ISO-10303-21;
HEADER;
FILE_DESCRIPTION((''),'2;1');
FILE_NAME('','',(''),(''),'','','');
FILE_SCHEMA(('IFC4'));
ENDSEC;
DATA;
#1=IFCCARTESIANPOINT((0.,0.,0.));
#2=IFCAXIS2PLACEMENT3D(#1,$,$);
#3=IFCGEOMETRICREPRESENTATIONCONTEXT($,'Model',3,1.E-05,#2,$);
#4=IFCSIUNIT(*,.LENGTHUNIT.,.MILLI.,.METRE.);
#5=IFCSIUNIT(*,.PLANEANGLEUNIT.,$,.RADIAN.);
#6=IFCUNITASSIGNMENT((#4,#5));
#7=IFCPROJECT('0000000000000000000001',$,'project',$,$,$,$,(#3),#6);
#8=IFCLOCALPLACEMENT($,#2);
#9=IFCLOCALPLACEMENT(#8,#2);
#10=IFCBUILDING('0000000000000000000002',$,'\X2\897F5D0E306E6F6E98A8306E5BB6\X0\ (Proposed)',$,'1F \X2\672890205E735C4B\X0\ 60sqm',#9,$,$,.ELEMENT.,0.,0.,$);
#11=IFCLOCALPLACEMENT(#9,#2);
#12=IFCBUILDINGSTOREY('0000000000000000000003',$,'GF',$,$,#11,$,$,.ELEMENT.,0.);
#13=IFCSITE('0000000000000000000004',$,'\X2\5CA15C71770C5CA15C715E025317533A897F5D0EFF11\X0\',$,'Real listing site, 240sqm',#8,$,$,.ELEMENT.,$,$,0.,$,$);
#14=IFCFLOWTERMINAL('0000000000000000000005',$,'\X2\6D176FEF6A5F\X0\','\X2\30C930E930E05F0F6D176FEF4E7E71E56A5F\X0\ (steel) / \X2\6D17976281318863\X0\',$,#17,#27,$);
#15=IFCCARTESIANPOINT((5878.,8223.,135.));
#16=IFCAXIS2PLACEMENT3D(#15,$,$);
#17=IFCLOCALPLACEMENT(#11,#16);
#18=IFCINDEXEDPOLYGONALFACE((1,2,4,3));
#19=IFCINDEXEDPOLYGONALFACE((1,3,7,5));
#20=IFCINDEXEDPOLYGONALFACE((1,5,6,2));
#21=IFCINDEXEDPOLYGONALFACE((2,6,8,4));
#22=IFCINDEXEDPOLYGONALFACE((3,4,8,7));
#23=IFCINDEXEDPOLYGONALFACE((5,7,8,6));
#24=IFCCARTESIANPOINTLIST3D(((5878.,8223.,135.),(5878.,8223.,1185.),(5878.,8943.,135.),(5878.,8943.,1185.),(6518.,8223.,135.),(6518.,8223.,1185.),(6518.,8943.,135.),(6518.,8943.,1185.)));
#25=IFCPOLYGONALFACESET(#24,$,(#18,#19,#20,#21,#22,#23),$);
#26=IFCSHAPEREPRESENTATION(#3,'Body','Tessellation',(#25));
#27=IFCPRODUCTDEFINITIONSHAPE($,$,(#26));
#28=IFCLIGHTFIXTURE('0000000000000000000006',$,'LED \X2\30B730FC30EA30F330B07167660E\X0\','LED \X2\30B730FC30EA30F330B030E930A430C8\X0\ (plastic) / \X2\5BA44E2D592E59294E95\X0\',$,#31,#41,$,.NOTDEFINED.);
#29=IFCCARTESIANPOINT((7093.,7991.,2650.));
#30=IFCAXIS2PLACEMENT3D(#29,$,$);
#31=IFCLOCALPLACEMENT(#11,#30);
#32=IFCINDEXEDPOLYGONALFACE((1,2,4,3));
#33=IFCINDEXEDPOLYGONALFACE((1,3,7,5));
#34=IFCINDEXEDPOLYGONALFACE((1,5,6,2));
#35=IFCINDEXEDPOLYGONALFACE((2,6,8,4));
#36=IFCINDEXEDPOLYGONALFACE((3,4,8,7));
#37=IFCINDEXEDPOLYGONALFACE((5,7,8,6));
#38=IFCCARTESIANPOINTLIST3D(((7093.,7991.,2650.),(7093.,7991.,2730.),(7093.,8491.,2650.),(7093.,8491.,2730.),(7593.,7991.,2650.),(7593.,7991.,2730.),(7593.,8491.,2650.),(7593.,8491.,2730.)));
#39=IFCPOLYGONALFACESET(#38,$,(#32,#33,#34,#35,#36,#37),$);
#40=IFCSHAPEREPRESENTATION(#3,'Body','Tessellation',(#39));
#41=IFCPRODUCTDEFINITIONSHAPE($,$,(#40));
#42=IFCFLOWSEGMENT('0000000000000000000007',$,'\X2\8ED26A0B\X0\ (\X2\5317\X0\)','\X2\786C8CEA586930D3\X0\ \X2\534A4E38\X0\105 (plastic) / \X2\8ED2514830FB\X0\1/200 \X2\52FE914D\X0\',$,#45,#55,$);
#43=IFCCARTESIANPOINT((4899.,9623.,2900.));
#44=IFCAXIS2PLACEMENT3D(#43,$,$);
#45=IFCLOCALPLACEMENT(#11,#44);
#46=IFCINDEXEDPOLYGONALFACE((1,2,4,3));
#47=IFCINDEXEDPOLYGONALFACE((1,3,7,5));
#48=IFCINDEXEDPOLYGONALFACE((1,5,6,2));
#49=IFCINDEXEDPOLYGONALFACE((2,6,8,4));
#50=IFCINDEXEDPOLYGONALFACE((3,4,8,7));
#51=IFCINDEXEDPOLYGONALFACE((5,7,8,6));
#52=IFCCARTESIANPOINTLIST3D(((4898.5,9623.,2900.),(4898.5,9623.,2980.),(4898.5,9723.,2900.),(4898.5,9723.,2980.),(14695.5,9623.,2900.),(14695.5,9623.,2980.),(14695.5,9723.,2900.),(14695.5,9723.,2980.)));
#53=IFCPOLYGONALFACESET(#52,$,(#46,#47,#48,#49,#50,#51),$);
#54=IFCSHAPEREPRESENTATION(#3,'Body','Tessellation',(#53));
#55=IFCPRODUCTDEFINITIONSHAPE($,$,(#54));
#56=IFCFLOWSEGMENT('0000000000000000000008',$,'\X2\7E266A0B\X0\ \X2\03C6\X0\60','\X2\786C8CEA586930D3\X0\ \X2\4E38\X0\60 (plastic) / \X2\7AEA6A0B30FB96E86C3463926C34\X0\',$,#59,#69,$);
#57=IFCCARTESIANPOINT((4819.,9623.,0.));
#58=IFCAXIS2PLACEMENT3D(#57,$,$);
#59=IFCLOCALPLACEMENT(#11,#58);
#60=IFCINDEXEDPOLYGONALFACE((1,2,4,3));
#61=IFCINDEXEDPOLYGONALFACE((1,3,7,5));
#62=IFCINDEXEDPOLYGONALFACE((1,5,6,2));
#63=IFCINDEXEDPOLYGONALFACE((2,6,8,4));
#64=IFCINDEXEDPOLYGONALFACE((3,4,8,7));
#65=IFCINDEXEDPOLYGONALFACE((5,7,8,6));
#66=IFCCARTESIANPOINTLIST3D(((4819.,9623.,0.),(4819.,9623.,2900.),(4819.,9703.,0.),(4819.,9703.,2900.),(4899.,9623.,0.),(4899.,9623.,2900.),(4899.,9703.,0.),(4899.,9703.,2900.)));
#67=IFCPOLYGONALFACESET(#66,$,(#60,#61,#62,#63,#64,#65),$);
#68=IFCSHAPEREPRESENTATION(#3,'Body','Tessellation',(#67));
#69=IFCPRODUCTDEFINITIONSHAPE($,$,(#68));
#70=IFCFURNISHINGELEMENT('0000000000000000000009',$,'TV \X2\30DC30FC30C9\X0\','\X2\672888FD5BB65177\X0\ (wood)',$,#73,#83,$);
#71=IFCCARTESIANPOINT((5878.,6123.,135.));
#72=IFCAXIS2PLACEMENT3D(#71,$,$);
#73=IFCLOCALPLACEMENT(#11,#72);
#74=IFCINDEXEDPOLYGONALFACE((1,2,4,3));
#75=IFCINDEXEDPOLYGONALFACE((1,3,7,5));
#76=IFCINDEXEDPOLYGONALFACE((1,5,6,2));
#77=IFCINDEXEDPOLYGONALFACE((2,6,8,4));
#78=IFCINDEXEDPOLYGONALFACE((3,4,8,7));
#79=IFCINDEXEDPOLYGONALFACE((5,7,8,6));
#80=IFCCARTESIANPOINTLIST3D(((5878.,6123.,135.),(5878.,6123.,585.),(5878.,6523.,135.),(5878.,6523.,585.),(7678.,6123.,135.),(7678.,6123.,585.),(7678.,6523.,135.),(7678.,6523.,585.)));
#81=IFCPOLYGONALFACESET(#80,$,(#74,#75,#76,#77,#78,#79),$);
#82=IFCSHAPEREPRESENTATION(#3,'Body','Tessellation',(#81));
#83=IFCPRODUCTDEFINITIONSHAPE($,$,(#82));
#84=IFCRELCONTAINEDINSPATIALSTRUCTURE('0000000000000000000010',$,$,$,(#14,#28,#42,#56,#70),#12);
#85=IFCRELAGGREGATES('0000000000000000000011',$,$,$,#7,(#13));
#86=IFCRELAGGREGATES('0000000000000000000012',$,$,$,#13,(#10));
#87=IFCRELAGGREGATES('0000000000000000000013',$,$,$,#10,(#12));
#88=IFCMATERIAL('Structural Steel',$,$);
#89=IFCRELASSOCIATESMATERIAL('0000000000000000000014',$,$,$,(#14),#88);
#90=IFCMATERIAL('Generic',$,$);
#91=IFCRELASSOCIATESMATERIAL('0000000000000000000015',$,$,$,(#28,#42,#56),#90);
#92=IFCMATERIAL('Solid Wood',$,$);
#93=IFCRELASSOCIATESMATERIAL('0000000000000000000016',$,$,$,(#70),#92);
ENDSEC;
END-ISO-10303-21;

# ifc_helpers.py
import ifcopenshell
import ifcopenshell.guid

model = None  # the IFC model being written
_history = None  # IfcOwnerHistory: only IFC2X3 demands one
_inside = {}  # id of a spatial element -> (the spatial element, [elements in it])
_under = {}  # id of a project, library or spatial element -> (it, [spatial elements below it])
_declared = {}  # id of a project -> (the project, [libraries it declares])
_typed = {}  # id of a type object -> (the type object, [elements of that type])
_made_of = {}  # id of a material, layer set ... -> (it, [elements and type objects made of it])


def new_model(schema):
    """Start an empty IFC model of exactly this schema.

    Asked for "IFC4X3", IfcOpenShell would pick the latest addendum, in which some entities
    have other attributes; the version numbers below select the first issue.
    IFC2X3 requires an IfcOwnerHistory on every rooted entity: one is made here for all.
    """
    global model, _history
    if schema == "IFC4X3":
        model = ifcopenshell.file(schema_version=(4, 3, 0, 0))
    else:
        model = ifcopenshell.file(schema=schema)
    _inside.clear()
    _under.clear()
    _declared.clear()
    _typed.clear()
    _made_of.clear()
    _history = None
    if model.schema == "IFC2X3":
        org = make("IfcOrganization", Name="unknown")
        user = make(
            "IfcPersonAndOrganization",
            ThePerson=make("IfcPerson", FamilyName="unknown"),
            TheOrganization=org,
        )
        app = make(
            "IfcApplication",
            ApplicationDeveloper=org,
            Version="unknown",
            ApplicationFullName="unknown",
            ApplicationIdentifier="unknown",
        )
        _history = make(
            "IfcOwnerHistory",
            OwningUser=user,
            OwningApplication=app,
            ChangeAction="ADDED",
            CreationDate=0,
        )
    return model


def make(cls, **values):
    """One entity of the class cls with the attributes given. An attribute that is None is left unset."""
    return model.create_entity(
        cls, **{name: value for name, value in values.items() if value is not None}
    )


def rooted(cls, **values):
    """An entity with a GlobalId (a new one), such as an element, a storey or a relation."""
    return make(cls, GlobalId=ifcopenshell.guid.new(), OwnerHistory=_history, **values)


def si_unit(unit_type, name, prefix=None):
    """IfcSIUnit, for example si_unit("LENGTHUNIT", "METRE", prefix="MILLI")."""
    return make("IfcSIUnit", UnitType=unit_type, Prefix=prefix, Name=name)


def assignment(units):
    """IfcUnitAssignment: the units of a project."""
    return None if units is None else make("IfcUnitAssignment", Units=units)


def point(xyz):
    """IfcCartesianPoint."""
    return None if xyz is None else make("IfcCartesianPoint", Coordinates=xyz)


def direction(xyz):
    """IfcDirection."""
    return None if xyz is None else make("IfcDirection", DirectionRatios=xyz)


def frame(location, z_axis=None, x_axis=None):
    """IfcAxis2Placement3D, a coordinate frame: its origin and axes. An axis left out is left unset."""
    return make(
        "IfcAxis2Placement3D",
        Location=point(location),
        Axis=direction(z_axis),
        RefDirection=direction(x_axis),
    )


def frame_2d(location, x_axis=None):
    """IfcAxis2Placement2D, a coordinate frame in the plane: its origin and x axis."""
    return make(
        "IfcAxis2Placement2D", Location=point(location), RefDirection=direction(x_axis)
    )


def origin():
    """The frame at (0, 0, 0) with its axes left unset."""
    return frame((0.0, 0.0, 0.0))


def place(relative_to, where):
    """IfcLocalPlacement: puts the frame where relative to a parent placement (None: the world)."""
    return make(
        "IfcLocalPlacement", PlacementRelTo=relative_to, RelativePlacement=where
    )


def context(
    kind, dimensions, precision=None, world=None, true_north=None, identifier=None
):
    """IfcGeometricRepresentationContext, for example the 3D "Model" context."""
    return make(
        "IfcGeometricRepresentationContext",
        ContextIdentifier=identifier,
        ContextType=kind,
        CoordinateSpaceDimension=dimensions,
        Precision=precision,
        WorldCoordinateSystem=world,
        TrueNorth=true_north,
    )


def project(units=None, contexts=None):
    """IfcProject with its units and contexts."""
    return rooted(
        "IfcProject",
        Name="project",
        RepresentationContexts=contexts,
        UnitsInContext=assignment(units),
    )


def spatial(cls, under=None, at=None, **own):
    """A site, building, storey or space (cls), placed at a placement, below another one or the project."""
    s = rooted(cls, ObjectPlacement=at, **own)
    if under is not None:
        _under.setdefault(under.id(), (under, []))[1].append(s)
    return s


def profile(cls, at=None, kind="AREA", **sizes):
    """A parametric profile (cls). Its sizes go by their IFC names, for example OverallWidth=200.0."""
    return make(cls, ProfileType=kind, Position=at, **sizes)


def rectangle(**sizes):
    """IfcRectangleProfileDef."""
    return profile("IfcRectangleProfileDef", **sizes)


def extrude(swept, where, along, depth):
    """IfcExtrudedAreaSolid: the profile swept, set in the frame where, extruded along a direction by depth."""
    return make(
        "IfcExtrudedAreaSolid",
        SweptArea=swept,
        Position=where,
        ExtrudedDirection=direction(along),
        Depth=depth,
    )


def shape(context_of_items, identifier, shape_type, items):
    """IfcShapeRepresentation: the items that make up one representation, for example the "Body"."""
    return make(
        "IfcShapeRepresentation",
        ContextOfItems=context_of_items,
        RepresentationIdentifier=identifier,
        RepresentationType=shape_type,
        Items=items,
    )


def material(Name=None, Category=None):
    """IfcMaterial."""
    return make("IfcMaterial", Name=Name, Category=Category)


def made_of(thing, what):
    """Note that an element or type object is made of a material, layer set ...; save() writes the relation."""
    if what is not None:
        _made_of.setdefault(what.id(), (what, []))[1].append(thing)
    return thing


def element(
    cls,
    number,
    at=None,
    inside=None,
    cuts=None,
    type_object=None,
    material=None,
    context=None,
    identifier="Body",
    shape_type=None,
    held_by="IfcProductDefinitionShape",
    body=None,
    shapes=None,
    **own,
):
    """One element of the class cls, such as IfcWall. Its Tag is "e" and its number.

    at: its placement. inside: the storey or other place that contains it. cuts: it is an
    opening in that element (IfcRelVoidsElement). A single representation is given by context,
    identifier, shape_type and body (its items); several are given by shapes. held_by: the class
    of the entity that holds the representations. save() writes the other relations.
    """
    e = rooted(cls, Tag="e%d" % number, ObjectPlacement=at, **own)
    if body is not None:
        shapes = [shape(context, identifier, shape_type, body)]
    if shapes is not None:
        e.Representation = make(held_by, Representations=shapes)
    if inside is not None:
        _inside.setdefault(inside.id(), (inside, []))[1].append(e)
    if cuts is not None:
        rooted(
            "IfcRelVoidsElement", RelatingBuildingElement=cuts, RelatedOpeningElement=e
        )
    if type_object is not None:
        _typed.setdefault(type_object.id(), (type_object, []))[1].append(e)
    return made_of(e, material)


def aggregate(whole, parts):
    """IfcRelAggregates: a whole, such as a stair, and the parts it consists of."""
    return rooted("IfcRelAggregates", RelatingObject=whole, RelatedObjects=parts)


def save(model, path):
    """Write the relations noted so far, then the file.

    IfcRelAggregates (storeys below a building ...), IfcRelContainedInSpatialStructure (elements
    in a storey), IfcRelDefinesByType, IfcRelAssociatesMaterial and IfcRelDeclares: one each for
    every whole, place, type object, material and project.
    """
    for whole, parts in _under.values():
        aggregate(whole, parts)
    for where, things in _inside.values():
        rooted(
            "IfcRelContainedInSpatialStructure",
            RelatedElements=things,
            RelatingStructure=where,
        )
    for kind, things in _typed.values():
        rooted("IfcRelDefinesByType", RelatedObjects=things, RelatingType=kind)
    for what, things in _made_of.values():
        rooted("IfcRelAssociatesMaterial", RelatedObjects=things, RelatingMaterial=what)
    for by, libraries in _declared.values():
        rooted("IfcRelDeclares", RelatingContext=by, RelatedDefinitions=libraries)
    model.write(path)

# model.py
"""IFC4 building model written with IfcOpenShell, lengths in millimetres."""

from ifc_helpers import new_model, si_unit, frame, frame_2d, origin, place, context, project, spatial, rectangle, extrude, material, element, save


model = new_model("IFC4")

# Units and contexts
model_context = context("Model", 3, precision=1e-05, world=origin())
ifc_project = project(units=[si_unit("LENGTHUNIT", "METRE", prefix="MILLI"), si_unit("PLANEANGLEUNIT", "RADIAN")], contexts=[model_context])

# Site, building, storey
site_placement = place(None, origin())
site = spatial("IfcSite", under=ifc_project, at=site_placement, Name="岡山県岡山市北区西崎１", ObjectType="Real listing site, 240sqm", CompositionType="ELEMENT", RefElevation=0.0)
building_placement = place(site_placement, origin())
building = spatial("IfcBuilding", under=site, at=building_placement, Name="西崎の潮風の家 (Proposed)", ObjectType="1F 木造平屋 60sqm", CompositionType="ELEMENT", ElevationOfRefHeight=0.0, ElevationOfTerrain=0.0)
storey_placement = place(building_placement, origin())
storey = spatial("IfcBuildingStorey", under=building, at=storey_placement, Name="GF", CompositionType="ELEMENT", Elevation=0.0)

# Shared definitions
ifc_material_1 = material(Name="Solid Wood")

# Shared definitions
ifc_material_2 = material(Name="Structural Steel")

# Shared definitions
ifc_material_3 = material(Name="Generic")

# Flow terminal
flow_terminal_placement = place(storey_placement, frame((5878.0, 8223.0, 135.0)))
element("IfcFlowTerminal", 1, at=flow_terminal_placement, inside=storey, material=ifc_material_2, Name="洗濯機", Description="ドラム式洗濯乾燥機 (steel) / 洗面脱衣", context=model_context, shape_type="SweptSolid", body=[
    extrude(rectangle(XDim=640.0, YDim=720.0, at=frame_2d((320.0, 360.0))), frame((5878.0, 8223.0, 135.0)), (0.0, 0.0, 1.0), 1050.0),
])

# Light fixture
light_fixture_placement = place(storey_placement, frame((7093.0, 7991.0, 2650.0)))
element("IfcLightFixture", 2, at=light_fixture_placement, inside=storey, material=ifc_material_3, Name="LED シーリング照明", Description="LED シーリングライト (plastic) / 室中央天井", PredefinedType="NOTDEFINED", context=model_context, shape_type="SweptSolid", body=[
    extrude(rectangle(XDim=500.0, YDim=500.0, at=frame_2d((250.0, 250.0))), frame((7093.0, 7991.0, 2650.0)), (0.0, 0.0, 1.0), 80.0),
])

# Flow segments
flow_segment_1_placement = place(storey_placement, frame((4899.0, 9623.0, 2900.0)))
element("IfcFlowSegment", 3, at=flow_segment_1_placement, inside=storey, material=ifc_material_3, Name="軒樋 (北)", Description="硬質塩ビ 半丸105 (plastic) / 軒先・1/200 勾配", context=model_context, shape_type="SweptSolid", body=[
    extrude(rectangle(XDim=9797.0, YDim=100.0, at=frame_2d((4898.0, 50.0))), frame((4899.0, 9623.0, 2900.0)), (0.0, 0.0, 1.0), 80.0),
])
flow_segment_2_placement = place(storey_placement, frame((4819.0, 9623.0, 0.0)))
element("IfcFlowSegment", 4, at=flow_segment_2_placement, inside=storey, material=ifc_material_3, Name="縦樋 φ60", Description="硬質塩ビ 丸60 (plastic) / 竪樋・雨水排水", context=model_context, shape_type="SweptSolid", body=[
    extrude(rectangle(XDim=80.0, YDim=80.0, at=frame_2d((40.0, 40.0))), frame((4819.0, 9623.0, 0.0)), (0.0, 0.0, 1.0), 2900.0),
])

# Furnishing element
furnishing_placement = place(storey_placement, frame((5878.0, 6123.0, 135.0)))
element("IfcFurnishingElement", 5, at=furnishing_placement, inside=storey, material=ifc_material_1, Name="TV ボード", Description="木製家具 (wood)", context=model_context, shape_type="SweptSolid", body=[
    extrude(rectangle(XDim=1800.0, YDim=400.0, at=frame_2d((900.0, 200.0))), frame((5878.0, 6123.0, 135.0)), (0.0, 0.0, 1.0), 450.0),
])

save(model, "model.ifc")
